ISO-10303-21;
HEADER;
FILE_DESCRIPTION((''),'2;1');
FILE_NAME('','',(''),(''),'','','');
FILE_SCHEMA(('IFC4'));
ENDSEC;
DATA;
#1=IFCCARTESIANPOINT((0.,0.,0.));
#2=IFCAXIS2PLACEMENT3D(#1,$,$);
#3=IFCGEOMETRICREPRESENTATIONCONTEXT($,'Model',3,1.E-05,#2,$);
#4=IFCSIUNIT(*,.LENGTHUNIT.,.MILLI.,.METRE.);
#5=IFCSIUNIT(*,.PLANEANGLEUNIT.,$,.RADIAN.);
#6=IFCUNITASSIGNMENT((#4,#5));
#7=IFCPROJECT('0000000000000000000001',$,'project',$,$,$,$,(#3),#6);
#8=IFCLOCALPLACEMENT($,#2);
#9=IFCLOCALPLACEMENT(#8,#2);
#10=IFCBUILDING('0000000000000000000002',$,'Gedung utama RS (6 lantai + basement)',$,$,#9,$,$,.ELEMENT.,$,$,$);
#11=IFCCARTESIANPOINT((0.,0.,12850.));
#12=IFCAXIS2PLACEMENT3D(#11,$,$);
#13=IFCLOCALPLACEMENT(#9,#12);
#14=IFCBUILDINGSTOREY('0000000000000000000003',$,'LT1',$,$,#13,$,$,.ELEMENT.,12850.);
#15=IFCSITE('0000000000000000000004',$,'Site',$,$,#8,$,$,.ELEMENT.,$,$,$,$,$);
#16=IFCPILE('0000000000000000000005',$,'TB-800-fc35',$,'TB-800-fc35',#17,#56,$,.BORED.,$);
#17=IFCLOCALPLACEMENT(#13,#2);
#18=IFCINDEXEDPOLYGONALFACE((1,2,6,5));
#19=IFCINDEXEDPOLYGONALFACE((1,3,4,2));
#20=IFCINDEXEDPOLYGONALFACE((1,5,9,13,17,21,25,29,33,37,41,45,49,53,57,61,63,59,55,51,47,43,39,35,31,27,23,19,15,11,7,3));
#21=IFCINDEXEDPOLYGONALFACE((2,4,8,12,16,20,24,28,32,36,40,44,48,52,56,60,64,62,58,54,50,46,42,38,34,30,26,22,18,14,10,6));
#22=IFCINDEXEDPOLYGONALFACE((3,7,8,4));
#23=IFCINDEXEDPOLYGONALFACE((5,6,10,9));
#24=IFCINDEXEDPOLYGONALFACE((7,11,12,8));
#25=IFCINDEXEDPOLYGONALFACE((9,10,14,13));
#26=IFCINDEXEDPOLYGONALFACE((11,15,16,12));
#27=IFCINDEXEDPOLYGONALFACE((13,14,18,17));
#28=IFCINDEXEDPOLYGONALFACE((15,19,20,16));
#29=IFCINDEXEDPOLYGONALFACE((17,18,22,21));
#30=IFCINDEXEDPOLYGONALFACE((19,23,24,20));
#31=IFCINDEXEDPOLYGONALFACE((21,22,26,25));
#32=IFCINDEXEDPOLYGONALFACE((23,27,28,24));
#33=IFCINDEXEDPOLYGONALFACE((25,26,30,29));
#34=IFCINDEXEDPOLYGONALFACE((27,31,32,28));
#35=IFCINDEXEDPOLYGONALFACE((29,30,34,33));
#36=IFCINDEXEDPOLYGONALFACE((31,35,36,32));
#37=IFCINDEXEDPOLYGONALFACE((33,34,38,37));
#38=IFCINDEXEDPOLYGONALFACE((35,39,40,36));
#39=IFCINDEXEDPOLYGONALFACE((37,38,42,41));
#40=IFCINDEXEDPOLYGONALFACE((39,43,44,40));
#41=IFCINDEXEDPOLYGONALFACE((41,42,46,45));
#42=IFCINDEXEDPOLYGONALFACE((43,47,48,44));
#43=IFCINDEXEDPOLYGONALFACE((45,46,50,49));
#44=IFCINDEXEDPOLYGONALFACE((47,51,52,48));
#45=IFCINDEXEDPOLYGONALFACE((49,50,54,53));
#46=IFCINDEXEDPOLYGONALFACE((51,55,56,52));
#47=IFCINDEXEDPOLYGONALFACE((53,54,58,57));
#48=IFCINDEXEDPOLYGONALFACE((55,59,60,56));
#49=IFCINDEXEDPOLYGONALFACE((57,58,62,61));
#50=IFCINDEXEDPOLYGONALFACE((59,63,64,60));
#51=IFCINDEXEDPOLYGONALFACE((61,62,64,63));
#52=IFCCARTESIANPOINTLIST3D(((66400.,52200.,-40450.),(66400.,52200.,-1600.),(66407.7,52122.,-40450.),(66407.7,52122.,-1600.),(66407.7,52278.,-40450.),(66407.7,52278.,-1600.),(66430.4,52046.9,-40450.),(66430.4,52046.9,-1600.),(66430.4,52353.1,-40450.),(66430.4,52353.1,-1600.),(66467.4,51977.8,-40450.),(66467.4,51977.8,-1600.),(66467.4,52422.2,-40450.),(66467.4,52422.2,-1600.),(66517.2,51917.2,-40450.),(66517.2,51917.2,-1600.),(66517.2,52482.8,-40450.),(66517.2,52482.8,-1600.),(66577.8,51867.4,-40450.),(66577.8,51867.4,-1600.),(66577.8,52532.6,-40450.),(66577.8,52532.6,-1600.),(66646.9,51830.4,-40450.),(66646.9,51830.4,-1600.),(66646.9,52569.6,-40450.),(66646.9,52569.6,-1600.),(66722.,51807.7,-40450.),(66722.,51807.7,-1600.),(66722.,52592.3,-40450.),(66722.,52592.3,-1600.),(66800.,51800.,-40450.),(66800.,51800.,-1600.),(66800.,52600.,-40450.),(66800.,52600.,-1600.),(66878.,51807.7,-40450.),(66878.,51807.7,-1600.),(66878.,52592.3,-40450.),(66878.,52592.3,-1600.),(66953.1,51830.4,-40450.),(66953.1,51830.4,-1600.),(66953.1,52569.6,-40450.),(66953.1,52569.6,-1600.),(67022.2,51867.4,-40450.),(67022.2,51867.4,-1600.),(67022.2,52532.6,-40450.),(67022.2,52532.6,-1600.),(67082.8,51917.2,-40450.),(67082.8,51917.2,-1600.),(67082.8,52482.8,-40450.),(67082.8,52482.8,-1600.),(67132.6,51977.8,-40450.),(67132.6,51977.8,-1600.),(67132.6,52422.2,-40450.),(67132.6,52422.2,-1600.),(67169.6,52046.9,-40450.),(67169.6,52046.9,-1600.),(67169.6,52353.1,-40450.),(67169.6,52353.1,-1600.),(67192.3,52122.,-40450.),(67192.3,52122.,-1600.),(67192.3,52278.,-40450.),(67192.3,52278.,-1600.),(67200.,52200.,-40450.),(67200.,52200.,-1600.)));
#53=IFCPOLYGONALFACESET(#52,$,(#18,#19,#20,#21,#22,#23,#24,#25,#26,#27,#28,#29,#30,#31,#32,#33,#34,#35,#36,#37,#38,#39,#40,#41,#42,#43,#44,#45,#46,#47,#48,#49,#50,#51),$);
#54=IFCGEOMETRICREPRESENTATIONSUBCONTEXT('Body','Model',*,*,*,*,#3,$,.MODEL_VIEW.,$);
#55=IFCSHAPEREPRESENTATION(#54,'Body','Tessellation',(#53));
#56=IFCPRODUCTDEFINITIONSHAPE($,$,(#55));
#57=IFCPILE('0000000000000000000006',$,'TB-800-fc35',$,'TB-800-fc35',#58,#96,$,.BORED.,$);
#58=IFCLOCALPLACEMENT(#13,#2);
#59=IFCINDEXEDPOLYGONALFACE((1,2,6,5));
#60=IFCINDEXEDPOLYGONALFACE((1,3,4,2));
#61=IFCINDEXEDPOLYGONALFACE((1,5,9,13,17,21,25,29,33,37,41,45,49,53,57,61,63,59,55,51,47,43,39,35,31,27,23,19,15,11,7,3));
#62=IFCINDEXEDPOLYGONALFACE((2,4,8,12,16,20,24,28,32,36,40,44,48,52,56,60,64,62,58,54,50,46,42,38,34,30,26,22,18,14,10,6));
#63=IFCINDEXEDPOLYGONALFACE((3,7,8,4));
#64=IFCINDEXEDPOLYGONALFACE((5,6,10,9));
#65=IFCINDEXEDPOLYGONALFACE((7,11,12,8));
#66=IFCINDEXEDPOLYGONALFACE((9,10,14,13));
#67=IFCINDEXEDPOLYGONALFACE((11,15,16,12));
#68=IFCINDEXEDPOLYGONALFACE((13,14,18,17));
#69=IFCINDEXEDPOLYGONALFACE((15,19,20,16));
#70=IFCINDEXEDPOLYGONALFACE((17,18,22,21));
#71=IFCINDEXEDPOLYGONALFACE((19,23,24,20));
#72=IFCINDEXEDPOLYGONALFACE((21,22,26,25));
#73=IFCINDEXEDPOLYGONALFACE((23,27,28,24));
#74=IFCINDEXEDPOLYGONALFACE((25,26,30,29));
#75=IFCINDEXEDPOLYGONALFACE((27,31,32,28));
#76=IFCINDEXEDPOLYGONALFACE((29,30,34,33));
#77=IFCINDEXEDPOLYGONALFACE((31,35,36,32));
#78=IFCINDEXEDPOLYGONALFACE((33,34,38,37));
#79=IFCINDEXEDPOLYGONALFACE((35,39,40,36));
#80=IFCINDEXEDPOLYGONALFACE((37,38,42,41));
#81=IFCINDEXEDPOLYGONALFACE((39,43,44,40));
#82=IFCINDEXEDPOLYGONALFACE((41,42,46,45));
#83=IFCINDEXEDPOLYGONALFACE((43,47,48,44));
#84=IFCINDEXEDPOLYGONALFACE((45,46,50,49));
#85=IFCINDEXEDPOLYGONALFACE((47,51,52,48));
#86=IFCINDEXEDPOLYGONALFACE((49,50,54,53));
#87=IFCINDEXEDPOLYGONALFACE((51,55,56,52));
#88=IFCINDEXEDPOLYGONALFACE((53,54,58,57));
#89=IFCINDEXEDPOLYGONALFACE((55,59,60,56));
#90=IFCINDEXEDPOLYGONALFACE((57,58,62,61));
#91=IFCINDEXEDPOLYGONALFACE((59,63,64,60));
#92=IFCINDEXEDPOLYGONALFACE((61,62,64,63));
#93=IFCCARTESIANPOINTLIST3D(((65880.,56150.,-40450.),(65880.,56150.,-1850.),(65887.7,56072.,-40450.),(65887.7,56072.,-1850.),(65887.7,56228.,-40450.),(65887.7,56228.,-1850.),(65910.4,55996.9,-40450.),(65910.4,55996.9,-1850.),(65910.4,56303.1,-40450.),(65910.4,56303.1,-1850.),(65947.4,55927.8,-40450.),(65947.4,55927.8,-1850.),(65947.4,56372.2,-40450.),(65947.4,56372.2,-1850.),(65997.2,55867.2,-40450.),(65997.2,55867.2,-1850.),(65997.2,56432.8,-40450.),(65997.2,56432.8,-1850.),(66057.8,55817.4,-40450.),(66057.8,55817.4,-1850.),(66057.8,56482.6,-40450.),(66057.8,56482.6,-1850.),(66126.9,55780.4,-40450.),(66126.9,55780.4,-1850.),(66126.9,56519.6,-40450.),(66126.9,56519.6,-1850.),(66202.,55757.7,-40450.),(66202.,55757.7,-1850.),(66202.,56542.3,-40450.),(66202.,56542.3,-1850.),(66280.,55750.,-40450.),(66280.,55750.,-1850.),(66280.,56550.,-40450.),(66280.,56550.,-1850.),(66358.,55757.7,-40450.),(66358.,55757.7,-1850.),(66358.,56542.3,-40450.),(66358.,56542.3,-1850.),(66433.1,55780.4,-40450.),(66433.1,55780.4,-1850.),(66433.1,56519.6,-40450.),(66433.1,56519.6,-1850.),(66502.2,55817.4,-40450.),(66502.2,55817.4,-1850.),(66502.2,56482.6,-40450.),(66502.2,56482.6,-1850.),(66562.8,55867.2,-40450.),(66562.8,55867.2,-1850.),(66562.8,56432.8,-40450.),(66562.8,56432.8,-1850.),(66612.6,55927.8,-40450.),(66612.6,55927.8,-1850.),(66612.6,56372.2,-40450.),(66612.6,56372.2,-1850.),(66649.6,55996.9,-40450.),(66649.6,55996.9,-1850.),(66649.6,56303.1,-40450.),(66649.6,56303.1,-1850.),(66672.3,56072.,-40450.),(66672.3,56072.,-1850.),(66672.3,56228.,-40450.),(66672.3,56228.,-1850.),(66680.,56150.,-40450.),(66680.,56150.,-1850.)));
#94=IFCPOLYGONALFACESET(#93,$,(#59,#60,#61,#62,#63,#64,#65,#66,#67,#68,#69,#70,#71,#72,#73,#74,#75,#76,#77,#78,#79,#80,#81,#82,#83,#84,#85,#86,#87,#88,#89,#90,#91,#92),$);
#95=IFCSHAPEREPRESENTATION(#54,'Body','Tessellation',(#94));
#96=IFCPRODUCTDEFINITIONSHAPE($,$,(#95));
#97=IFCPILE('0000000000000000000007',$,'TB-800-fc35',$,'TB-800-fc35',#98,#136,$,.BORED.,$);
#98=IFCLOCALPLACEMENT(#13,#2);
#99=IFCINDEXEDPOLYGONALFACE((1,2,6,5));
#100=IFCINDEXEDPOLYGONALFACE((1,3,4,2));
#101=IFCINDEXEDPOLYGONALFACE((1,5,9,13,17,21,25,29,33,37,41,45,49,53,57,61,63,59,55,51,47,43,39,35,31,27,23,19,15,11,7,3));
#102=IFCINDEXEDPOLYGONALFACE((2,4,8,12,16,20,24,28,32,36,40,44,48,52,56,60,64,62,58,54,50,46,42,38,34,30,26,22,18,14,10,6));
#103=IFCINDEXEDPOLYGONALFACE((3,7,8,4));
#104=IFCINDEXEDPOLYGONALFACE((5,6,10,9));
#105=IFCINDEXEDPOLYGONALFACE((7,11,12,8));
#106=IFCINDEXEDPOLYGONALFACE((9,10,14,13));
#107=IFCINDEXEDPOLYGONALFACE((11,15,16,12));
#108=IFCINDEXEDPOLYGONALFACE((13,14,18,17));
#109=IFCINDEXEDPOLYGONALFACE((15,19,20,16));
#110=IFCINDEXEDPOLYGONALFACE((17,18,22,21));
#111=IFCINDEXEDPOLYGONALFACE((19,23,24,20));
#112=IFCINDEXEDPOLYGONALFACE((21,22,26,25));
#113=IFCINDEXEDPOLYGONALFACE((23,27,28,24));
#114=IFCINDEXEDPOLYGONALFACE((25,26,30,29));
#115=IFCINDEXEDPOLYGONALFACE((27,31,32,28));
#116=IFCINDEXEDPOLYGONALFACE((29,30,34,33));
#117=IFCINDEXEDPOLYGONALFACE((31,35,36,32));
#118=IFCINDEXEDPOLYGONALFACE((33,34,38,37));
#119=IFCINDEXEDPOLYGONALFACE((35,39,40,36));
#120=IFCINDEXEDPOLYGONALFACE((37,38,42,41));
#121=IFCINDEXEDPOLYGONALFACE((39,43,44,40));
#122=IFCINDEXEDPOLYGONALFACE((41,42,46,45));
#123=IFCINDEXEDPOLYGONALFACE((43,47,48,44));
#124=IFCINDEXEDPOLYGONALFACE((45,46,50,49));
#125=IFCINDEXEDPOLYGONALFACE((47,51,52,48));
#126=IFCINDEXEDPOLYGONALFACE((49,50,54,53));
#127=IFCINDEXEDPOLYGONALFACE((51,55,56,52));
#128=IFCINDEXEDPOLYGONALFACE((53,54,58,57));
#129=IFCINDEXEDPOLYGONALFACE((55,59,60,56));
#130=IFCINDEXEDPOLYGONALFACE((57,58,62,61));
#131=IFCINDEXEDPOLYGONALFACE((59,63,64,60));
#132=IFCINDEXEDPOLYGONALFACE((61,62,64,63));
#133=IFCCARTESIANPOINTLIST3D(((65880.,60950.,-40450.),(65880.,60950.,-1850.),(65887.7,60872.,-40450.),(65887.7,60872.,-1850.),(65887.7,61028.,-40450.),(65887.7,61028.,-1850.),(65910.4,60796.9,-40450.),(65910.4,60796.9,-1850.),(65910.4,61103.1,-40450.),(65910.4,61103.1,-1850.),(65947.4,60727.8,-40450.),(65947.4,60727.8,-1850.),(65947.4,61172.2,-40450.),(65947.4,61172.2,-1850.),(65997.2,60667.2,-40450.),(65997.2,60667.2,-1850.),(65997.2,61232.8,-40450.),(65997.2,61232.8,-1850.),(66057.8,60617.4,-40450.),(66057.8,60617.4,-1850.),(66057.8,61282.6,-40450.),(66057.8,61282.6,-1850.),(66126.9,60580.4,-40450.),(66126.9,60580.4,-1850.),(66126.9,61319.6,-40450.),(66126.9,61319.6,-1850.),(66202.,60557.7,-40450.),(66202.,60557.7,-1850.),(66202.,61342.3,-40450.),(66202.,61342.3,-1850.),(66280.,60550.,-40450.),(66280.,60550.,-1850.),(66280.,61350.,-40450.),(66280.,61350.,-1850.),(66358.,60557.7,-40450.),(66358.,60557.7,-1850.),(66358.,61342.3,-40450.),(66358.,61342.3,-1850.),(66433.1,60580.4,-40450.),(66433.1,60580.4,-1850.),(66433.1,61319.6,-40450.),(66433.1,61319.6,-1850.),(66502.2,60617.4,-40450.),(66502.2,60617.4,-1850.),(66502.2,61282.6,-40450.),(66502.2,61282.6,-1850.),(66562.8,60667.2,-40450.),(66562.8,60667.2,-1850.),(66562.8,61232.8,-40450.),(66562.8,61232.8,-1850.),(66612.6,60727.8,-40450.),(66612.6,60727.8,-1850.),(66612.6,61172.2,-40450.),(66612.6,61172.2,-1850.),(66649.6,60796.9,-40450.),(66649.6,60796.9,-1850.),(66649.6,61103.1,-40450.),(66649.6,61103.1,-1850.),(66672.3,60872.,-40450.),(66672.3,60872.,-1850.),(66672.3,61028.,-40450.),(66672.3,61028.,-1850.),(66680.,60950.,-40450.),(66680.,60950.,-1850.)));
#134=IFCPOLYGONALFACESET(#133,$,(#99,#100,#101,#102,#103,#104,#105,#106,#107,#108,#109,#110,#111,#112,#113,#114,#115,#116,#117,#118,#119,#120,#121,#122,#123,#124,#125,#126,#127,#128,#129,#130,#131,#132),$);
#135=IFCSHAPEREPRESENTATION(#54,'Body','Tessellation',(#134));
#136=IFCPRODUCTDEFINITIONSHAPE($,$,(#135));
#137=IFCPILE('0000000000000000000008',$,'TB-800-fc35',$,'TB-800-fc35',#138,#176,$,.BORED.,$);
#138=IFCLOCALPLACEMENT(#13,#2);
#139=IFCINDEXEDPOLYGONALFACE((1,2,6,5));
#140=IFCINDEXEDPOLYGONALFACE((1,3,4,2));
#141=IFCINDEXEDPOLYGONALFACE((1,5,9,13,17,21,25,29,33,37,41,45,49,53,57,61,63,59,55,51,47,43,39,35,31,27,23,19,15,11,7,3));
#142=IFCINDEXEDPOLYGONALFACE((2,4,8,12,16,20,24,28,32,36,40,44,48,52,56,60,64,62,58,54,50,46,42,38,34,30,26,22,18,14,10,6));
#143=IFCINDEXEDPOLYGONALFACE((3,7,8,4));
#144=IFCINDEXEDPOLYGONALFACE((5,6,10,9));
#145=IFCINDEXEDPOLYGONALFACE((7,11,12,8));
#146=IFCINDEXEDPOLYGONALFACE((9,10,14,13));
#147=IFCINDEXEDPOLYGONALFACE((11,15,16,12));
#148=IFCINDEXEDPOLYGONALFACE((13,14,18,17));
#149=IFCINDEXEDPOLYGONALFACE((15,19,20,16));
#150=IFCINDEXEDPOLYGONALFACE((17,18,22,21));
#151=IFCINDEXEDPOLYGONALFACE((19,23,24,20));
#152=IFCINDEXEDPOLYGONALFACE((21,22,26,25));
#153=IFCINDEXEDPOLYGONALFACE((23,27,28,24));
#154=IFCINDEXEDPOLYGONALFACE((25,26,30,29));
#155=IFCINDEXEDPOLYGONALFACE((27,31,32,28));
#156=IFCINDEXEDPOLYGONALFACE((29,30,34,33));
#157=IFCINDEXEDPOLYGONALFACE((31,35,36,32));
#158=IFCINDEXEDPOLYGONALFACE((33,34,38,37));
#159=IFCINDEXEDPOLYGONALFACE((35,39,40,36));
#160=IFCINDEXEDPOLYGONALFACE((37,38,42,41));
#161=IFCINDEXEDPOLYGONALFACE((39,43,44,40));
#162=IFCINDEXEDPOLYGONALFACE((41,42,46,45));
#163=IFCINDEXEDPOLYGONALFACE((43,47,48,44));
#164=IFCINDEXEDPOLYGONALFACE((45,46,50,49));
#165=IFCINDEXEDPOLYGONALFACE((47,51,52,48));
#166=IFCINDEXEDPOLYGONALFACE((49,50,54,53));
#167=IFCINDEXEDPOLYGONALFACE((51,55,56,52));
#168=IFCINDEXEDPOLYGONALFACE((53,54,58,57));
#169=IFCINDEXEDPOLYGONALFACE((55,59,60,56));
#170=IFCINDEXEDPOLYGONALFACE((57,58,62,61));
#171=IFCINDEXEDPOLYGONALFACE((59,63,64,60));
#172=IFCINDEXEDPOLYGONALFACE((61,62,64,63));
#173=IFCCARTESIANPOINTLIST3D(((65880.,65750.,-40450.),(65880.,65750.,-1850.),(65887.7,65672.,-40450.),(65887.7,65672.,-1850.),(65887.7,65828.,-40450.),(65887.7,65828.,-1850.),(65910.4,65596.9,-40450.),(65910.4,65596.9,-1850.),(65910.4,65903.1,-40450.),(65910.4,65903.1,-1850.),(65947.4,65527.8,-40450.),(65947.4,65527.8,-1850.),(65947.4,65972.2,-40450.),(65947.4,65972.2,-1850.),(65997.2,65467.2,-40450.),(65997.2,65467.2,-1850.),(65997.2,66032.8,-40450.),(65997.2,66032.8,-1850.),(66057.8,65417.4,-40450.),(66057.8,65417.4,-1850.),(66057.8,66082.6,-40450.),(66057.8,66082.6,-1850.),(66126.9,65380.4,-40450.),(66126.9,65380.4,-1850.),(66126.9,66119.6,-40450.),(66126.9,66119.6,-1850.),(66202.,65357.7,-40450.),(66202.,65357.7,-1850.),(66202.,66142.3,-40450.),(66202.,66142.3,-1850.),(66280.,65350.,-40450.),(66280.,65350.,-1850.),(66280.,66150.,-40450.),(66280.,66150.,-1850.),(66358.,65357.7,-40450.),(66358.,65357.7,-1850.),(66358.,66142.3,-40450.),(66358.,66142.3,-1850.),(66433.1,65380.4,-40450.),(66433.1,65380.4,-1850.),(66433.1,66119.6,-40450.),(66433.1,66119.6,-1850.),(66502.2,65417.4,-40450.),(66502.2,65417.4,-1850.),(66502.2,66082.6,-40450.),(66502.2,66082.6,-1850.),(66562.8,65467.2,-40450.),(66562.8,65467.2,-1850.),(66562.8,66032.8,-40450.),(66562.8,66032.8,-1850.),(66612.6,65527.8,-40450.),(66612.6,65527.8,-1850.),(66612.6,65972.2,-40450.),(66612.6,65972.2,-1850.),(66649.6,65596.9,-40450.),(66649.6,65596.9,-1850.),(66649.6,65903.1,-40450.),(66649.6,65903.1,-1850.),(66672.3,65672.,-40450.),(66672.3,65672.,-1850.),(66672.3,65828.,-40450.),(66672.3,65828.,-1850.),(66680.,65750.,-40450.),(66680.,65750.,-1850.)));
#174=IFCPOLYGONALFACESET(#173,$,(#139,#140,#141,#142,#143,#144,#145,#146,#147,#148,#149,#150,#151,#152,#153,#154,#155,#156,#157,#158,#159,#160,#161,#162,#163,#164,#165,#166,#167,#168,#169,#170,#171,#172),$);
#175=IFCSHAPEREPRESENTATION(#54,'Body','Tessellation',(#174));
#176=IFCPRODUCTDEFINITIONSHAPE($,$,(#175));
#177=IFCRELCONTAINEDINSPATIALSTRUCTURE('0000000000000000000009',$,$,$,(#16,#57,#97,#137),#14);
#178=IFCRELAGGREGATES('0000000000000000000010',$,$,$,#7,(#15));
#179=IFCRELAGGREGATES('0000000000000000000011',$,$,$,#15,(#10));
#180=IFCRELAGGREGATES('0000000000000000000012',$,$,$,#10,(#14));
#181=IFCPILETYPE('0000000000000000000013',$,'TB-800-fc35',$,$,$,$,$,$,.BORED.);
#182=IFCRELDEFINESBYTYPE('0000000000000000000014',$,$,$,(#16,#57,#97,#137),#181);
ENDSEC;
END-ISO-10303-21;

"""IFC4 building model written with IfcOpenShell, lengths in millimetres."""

from ifc_helpers import new_model, si_unit, frame, origin, origin_2d, place, context, subcontext, project, spatial, circle, extrude, material_profile, profile_set, profile_usage, type_object, element, save


model = new_model("IFC4")

# Units and contexts
model_context = context("Model", 3, precision=1e-05, world=origin())
body_context = subcontext(model_context, "Body", "Model", "MODEL_VIEW")
ifc_project = project(units=[si_unit("LENGTHUNIT", "METRE", prefix="MILLI"), si_unit("PLANEANGLEUNIT", "RADIAN")], contexts=[model_context])

# Site, building, storey
site_placement = place(None, origin())
site = spatial("IfcSite", under=ifc_project, at=site_placement, Name="Site", CompositionType="ELEMENT")
building_placement = place(site_placement, origin())
building = spatial("IfcBuilding", under=site, at=building_placement, Name="Gedung utama RS (6 lantai + basement)", CompositionType="ELEMENT")
storey_placement = place(building_placement, frame((0.0, 0.0, 12850.0)))
storey = spatial("IfcBuildingStorey", under=building, at=storey_placement, Name="LT1", CompositionType="ELEMENT", Elevation=12850.0)

# Piles
ifc_material_profile = material_profile(None, circle(Radius=400.0, at=origin_2d()), Name="TB-800-fc35")
ifc_profile_set = profile_set([ifc_material_profile], Name="TB-800-fc35")
ifc_profile_usage = profile_usage(ifc_profile_set, cardinal=5)
pile_type = type_object("IfcPileType", Name="TB-800-fc35", PredefinedType="BORED")
for number, where, z_axis, x_axis, name in (
    (1, (66800.0, 52200.0, -40450.0), (0.0, 0.0, 1.0), (1.0, 0.0, 0.0), "TB-800-fc35"),
):
    element("IfcPile", number, at=place(storey_placement, frame(where, z_axis=z_axis, x_axis=x_axis)), inside=storey, type_object=pile_type, material=ifc_profile_usage, Name=name, ObjectType="TB-800-fc35", PredefinedType="BORED", context=body_context, shape_type="SweptSolid", body=[
        extrude(circle(Radius=400.0, at=origin_2d()), origin(), (0.0, 0.0, 1.0), 38850.0),
    ])
for number, where, z_axis, x_axis, name in (
    (2, (66280.0, 56150.0, -40450.0), (0.0, 0.0, 1.0), (1.0, 0.0, 0.0), "TB-800-fc35"),
    (3, (66280.0, 60950.0, -40450.0), (0.0, 0.0, 1.0), (1.0, 0.0, 0.0), "TB-800-fc35"),
    (4, (66280.0, 65750.0, -40450.0), (0.0, 0.0, 1.0), (1.0, 0.0, 0.0), "TB-800-fc35"),
):
    element("IfcPile", number, at=place(storey_placement, frame(where, z_axis=z_axis, x_axis=x_axis)), inside=storey, type_object=pile_type, material=ifc_profile_usage, Name=name, ObjectType="TB-800-fc35", PredefinedType="BORED", context=body_context, shape_type="SweptSolid", body=[
        extrude(circle(Radius=400.0, at=origin_2d()), origin(), (0.0, 0.0, 1.0), 38600.0),
    ])

save(model, "model.ifc")
